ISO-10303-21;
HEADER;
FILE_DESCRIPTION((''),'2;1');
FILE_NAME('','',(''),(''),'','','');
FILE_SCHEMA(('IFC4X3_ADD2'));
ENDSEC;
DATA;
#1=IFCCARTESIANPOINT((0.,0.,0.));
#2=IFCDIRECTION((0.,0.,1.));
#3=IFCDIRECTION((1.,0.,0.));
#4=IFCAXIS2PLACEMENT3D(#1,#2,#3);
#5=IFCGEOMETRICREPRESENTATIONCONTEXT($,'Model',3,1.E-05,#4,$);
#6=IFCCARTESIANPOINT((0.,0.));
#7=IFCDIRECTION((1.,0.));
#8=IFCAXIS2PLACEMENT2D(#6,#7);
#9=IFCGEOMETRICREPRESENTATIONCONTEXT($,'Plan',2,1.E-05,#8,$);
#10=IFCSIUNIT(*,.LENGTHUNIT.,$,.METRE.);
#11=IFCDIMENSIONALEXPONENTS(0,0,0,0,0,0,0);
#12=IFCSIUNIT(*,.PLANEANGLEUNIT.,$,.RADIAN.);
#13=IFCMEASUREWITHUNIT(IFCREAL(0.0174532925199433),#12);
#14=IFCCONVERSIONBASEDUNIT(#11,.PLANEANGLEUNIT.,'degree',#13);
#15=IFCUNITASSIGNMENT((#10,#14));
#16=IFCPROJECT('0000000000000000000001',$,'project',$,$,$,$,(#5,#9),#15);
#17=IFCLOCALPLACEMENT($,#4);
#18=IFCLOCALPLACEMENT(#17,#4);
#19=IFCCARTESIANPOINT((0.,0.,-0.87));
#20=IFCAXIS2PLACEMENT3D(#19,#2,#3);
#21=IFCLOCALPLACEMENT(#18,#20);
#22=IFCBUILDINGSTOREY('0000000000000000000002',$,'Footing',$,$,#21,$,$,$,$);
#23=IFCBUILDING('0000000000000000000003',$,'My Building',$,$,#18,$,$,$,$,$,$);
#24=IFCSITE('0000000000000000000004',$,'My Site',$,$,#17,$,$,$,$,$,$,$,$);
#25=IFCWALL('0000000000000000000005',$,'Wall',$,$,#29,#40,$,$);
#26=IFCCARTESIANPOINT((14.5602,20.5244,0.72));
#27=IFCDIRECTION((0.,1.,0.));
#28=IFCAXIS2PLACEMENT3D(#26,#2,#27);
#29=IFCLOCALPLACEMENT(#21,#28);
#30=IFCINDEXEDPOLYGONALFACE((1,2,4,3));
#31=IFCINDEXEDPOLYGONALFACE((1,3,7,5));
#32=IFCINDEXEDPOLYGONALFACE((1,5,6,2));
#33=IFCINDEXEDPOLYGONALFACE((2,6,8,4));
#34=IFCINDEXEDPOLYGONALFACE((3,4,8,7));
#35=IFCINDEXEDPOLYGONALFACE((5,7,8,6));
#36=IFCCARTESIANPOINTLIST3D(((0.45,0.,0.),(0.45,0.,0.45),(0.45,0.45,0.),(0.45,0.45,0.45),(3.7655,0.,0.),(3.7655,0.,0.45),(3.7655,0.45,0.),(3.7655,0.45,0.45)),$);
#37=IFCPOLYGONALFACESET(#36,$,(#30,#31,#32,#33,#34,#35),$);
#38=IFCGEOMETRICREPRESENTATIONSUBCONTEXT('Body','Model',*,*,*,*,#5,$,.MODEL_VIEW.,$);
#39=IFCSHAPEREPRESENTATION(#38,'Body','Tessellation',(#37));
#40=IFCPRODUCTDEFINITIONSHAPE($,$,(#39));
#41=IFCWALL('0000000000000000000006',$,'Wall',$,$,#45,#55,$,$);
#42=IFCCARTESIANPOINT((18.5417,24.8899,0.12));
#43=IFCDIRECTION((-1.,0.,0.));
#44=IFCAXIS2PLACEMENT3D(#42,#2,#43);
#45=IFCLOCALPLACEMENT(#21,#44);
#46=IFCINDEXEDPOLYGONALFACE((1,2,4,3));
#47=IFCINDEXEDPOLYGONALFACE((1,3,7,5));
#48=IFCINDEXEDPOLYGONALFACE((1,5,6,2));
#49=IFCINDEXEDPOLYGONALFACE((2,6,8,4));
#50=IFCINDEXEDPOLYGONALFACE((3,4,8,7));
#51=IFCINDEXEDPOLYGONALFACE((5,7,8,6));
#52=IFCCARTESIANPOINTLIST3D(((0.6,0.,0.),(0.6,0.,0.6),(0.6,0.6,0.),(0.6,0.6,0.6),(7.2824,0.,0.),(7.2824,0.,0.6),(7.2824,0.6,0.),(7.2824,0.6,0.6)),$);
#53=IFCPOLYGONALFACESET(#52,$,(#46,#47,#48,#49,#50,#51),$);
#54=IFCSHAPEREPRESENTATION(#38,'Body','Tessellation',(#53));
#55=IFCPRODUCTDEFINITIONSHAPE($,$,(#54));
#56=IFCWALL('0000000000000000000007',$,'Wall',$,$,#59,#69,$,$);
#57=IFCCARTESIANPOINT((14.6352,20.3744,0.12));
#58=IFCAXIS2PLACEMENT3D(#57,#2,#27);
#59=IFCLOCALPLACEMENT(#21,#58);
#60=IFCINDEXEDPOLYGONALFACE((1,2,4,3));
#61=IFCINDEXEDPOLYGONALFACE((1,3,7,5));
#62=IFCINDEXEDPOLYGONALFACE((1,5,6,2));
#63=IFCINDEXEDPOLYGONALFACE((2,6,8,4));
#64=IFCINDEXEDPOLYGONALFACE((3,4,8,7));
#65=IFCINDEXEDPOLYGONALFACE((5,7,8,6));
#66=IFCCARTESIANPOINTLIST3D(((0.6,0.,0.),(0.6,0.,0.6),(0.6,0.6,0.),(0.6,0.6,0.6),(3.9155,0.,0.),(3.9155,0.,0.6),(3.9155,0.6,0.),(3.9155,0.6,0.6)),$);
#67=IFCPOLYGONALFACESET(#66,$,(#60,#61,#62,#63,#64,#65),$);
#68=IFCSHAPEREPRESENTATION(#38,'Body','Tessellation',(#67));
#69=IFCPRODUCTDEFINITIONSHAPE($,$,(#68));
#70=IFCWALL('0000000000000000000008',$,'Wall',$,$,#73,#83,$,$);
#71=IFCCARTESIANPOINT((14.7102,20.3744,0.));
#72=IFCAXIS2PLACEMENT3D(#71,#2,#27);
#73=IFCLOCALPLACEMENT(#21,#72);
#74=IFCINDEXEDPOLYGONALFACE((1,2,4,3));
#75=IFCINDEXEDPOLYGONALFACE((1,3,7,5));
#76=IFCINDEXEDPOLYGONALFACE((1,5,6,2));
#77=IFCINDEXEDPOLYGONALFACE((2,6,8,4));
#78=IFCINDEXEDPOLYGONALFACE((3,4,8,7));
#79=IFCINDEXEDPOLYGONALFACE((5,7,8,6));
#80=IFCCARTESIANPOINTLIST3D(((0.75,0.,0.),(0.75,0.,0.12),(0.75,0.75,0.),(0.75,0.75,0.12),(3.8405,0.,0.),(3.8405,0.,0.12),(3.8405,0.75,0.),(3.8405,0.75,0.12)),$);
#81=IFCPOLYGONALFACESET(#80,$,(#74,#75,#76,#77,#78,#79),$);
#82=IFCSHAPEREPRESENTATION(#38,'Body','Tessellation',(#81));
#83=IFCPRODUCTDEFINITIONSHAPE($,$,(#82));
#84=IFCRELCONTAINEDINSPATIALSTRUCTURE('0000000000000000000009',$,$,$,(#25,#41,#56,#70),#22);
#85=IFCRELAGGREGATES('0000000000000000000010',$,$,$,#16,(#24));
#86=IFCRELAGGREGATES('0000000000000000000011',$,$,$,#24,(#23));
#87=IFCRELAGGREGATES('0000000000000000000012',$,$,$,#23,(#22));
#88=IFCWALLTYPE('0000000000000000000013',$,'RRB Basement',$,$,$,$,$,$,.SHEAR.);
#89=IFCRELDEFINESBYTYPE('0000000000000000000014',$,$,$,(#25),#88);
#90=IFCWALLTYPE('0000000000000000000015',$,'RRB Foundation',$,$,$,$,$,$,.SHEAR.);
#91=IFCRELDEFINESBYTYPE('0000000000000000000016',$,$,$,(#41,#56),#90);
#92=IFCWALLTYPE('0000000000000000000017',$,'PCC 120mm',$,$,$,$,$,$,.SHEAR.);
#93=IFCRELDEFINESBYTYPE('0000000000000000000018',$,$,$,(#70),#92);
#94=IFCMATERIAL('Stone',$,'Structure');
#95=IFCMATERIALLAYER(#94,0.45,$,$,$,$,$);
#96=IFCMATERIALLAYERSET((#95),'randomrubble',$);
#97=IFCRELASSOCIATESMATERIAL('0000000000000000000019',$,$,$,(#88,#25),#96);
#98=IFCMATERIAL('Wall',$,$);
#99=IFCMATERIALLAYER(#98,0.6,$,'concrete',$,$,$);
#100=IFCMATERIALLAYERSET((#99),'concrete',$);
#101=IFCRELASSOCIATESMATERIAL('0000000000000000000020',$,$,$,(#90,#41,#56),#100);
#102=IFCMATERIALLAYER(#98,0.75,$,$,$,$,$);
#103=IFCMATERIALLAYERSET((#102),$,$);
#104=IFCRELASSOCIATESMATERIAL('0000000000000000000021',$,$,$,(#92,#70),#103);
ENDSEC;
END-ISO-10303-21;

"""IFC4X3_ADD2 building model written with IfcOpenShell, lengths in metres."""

from ifc_helpers import new_model, entity, si_unit, converted_unit, frame, origin_with_axes, origin_2d_with_axis, place, context, subcontext, project, spatial, line, indexed_curve, outline, extrude, material, layer, layer_set, layer_usage, type_object, element, save


model = new_model("IFC4X3_ADD2")

# Units and contexts
model_context = context("Model", 3, precision=1e-05, world=origin_with_axes())
plan_context = context("Plan", 2, precision=1e-05, world=origin_2d_with_axis())
body_context = subcontext(model_context, "Body", "Model", "MODEL_VIEW")
ifc_project = project(units=[si_unit("LENGTHUNIT", "METRE"), converted_unit("PLANEANGLEUNIT", "degree", entity("IfcReal", 0.0174532925199433), si_unit("PLANEANGLEUNIT", "RADIAN"), dimensions=[0, 0, 0, 0, 0, 0, 0])], contexts=[model_context, plan_context])

# Site, building, storey
site_placement = place(None, origin_with_axes())
site = spatial("IfcSite", under=ifc_project, at=site_placement, Name="My Site")
building_placement = place(site_placement, origin_with_axes())
building = spatial("IfcBuilding", under=site, at=building_placement, Name="My Building")
storey_placement = place(building_placement, frame((0.0, 0.0, -0.87), z_axis=(0.0, 0.0, 1.0), x_axis=(1.0, 0.0, 0.0)))
storey = spatial("IfcBuildingStorey", under=building, at=storey_placement, Name="Footing")

# Shared definitions
ifc_material_1 = material(Name="Stone", Category="Structure")

# Walls
ifc_layer_1 = layer(ifc_material_1, 0.45)
ifc_layer_set_1 = layer_set([ifc_layer_1], Name="randomrubble")
wall_type_1 = type_object("IfcWallType", Name="RRB Basement", PredefinedType="SHEAR", material=ifc_layer_set_1)
ifc_layer_usage_1 = layer_usage(ifc_layer_set_1, "AXIS2", "POSITIVE", 0.0)
wall_1_placement = place(storey_placement, frame((14.5602, 20.5244, 0.72), z_axis=(0.0, 0.0, 1.0), x_axis=(0.0, 1.0, 0.0)))
element("IfcWall", 1, at=wall_1_placement, inside=storey, type_object=wall_type_1, material=ifc_layer_usage_1, Name="Wall", context=body_context, shape_type="SweptSolid", body=[
    extrude(outline(indexed_curve([(0.45, 0.0), (0.45, 0.45), (3.7655, 0.45), (3.7655, 0.0)], segments=[line(1, 2, 3, 4, 1)])), origin_with_axes(), (0.0, 0.0, 1.0), 0.45),
])
ifc_material_2 = material(Name="Wall")
ifc_layer_2 = layer(ifc_material_2, 0.6, Name="concrete")
ifc_layer_set_2 = layer_set([ifc_layer_2], Name="concrete")
wall_type_2 = type_object("IfcWallType", Name="RRB Foundation", PredefinedType="SHEAR", material=ifc_layer_set_2)
ifc_layer_usage_2 = layer_usage(ifc_layer_set_2, "AXIS2", "POSITIVE", 0.0)
wall_2_placement = place(storey_placement, frame((18.5417, 24.8899, 0.12), z_axis=(0.0, 0.0, 1.0), x_axis=(-1.0, 0.0, 0.0)))
element("IfcWall", 2, at=wall_2_placement, inside=storey, type_object=wall_type_2, material=ifc_layer_usage_2, Name="Wall", context=body_context, shape_type="SweptSolid", body=[
    extrude(outline(indexed_curve([(0.6, 0.0), (0.6, 0.6), (7.2824, 0.6), (7.2824, 0.0)], segments=[line(1, 2, 3, 4, 1)])), origin_with_axes(), (0.0, 0.0, 1.0), 0.6),
])
ifc_layer_usage_3 = layer_usage(ifc_layer_set_2, "AXIS2", "POSITIVE", 0.0)
wall_3_placement = place(storey_placement, frame((14.6352, 20.3744, 0.12), z_axis=(0.0, 0.0, 1.0), x_axis=(0.0, 1.0, 0.0)))
element("IfcWall", 3, at=wall_3_placement, inside=storey, type_object=wall_type_2, material=ifc_layer_usage_3, Name="Wall", context=body_context, shape_type="SweptSolid", body=[
    extrude(outline(indexed_curve([(0.6, 0.0), (0.6, 0.6), (3.9155, 0.6), (3.9155, 0.0)], segments=[line(1, 2, 3, 4, 1)])), origin_with_axes(), (0.0, 0.0, 1.0), 0.6),
])
ifc_layer_3 = layer(ifc_material_2, 0.75)
ifc_layer_set_3 = layer_set([ifc_layer_3])
ifc_layer_usage_4 = layer_usage(ifc_layer_set_3, "AXIS2", "POSITIVE", 0.0)
wall_type_3 = type_object("IfcWallType", Name="PCC 120mm", PredefinedType="SHEAR", material=ifc_layer_set_3)
wall_4_placement = place(storey_placement, frame((14.7102, 20.3744, 0.0), z_axis=(0.0, 0.0, 1.0), x_axis=(0.0, 1.0, 0.0)))
element("IfcWall", 4, at=wall_4_placement, inside=storey, type_object=wall_type_3, material=ifc_layer_usage_4, Name="Wall", context=body_context, shape_type="SweptSolid", body=[
    extrude(outline(indexed_curve([(0.75, 0.0), (0.75, 0.75), (3.8405, 0.75), (3.8405, 0.0)], segments=[line(1, 2, 3, 4, 1)])), origin_with_axes(), (0.0, 0.0, 1.0), 0.12),
])

save(model, "model.ifc")
